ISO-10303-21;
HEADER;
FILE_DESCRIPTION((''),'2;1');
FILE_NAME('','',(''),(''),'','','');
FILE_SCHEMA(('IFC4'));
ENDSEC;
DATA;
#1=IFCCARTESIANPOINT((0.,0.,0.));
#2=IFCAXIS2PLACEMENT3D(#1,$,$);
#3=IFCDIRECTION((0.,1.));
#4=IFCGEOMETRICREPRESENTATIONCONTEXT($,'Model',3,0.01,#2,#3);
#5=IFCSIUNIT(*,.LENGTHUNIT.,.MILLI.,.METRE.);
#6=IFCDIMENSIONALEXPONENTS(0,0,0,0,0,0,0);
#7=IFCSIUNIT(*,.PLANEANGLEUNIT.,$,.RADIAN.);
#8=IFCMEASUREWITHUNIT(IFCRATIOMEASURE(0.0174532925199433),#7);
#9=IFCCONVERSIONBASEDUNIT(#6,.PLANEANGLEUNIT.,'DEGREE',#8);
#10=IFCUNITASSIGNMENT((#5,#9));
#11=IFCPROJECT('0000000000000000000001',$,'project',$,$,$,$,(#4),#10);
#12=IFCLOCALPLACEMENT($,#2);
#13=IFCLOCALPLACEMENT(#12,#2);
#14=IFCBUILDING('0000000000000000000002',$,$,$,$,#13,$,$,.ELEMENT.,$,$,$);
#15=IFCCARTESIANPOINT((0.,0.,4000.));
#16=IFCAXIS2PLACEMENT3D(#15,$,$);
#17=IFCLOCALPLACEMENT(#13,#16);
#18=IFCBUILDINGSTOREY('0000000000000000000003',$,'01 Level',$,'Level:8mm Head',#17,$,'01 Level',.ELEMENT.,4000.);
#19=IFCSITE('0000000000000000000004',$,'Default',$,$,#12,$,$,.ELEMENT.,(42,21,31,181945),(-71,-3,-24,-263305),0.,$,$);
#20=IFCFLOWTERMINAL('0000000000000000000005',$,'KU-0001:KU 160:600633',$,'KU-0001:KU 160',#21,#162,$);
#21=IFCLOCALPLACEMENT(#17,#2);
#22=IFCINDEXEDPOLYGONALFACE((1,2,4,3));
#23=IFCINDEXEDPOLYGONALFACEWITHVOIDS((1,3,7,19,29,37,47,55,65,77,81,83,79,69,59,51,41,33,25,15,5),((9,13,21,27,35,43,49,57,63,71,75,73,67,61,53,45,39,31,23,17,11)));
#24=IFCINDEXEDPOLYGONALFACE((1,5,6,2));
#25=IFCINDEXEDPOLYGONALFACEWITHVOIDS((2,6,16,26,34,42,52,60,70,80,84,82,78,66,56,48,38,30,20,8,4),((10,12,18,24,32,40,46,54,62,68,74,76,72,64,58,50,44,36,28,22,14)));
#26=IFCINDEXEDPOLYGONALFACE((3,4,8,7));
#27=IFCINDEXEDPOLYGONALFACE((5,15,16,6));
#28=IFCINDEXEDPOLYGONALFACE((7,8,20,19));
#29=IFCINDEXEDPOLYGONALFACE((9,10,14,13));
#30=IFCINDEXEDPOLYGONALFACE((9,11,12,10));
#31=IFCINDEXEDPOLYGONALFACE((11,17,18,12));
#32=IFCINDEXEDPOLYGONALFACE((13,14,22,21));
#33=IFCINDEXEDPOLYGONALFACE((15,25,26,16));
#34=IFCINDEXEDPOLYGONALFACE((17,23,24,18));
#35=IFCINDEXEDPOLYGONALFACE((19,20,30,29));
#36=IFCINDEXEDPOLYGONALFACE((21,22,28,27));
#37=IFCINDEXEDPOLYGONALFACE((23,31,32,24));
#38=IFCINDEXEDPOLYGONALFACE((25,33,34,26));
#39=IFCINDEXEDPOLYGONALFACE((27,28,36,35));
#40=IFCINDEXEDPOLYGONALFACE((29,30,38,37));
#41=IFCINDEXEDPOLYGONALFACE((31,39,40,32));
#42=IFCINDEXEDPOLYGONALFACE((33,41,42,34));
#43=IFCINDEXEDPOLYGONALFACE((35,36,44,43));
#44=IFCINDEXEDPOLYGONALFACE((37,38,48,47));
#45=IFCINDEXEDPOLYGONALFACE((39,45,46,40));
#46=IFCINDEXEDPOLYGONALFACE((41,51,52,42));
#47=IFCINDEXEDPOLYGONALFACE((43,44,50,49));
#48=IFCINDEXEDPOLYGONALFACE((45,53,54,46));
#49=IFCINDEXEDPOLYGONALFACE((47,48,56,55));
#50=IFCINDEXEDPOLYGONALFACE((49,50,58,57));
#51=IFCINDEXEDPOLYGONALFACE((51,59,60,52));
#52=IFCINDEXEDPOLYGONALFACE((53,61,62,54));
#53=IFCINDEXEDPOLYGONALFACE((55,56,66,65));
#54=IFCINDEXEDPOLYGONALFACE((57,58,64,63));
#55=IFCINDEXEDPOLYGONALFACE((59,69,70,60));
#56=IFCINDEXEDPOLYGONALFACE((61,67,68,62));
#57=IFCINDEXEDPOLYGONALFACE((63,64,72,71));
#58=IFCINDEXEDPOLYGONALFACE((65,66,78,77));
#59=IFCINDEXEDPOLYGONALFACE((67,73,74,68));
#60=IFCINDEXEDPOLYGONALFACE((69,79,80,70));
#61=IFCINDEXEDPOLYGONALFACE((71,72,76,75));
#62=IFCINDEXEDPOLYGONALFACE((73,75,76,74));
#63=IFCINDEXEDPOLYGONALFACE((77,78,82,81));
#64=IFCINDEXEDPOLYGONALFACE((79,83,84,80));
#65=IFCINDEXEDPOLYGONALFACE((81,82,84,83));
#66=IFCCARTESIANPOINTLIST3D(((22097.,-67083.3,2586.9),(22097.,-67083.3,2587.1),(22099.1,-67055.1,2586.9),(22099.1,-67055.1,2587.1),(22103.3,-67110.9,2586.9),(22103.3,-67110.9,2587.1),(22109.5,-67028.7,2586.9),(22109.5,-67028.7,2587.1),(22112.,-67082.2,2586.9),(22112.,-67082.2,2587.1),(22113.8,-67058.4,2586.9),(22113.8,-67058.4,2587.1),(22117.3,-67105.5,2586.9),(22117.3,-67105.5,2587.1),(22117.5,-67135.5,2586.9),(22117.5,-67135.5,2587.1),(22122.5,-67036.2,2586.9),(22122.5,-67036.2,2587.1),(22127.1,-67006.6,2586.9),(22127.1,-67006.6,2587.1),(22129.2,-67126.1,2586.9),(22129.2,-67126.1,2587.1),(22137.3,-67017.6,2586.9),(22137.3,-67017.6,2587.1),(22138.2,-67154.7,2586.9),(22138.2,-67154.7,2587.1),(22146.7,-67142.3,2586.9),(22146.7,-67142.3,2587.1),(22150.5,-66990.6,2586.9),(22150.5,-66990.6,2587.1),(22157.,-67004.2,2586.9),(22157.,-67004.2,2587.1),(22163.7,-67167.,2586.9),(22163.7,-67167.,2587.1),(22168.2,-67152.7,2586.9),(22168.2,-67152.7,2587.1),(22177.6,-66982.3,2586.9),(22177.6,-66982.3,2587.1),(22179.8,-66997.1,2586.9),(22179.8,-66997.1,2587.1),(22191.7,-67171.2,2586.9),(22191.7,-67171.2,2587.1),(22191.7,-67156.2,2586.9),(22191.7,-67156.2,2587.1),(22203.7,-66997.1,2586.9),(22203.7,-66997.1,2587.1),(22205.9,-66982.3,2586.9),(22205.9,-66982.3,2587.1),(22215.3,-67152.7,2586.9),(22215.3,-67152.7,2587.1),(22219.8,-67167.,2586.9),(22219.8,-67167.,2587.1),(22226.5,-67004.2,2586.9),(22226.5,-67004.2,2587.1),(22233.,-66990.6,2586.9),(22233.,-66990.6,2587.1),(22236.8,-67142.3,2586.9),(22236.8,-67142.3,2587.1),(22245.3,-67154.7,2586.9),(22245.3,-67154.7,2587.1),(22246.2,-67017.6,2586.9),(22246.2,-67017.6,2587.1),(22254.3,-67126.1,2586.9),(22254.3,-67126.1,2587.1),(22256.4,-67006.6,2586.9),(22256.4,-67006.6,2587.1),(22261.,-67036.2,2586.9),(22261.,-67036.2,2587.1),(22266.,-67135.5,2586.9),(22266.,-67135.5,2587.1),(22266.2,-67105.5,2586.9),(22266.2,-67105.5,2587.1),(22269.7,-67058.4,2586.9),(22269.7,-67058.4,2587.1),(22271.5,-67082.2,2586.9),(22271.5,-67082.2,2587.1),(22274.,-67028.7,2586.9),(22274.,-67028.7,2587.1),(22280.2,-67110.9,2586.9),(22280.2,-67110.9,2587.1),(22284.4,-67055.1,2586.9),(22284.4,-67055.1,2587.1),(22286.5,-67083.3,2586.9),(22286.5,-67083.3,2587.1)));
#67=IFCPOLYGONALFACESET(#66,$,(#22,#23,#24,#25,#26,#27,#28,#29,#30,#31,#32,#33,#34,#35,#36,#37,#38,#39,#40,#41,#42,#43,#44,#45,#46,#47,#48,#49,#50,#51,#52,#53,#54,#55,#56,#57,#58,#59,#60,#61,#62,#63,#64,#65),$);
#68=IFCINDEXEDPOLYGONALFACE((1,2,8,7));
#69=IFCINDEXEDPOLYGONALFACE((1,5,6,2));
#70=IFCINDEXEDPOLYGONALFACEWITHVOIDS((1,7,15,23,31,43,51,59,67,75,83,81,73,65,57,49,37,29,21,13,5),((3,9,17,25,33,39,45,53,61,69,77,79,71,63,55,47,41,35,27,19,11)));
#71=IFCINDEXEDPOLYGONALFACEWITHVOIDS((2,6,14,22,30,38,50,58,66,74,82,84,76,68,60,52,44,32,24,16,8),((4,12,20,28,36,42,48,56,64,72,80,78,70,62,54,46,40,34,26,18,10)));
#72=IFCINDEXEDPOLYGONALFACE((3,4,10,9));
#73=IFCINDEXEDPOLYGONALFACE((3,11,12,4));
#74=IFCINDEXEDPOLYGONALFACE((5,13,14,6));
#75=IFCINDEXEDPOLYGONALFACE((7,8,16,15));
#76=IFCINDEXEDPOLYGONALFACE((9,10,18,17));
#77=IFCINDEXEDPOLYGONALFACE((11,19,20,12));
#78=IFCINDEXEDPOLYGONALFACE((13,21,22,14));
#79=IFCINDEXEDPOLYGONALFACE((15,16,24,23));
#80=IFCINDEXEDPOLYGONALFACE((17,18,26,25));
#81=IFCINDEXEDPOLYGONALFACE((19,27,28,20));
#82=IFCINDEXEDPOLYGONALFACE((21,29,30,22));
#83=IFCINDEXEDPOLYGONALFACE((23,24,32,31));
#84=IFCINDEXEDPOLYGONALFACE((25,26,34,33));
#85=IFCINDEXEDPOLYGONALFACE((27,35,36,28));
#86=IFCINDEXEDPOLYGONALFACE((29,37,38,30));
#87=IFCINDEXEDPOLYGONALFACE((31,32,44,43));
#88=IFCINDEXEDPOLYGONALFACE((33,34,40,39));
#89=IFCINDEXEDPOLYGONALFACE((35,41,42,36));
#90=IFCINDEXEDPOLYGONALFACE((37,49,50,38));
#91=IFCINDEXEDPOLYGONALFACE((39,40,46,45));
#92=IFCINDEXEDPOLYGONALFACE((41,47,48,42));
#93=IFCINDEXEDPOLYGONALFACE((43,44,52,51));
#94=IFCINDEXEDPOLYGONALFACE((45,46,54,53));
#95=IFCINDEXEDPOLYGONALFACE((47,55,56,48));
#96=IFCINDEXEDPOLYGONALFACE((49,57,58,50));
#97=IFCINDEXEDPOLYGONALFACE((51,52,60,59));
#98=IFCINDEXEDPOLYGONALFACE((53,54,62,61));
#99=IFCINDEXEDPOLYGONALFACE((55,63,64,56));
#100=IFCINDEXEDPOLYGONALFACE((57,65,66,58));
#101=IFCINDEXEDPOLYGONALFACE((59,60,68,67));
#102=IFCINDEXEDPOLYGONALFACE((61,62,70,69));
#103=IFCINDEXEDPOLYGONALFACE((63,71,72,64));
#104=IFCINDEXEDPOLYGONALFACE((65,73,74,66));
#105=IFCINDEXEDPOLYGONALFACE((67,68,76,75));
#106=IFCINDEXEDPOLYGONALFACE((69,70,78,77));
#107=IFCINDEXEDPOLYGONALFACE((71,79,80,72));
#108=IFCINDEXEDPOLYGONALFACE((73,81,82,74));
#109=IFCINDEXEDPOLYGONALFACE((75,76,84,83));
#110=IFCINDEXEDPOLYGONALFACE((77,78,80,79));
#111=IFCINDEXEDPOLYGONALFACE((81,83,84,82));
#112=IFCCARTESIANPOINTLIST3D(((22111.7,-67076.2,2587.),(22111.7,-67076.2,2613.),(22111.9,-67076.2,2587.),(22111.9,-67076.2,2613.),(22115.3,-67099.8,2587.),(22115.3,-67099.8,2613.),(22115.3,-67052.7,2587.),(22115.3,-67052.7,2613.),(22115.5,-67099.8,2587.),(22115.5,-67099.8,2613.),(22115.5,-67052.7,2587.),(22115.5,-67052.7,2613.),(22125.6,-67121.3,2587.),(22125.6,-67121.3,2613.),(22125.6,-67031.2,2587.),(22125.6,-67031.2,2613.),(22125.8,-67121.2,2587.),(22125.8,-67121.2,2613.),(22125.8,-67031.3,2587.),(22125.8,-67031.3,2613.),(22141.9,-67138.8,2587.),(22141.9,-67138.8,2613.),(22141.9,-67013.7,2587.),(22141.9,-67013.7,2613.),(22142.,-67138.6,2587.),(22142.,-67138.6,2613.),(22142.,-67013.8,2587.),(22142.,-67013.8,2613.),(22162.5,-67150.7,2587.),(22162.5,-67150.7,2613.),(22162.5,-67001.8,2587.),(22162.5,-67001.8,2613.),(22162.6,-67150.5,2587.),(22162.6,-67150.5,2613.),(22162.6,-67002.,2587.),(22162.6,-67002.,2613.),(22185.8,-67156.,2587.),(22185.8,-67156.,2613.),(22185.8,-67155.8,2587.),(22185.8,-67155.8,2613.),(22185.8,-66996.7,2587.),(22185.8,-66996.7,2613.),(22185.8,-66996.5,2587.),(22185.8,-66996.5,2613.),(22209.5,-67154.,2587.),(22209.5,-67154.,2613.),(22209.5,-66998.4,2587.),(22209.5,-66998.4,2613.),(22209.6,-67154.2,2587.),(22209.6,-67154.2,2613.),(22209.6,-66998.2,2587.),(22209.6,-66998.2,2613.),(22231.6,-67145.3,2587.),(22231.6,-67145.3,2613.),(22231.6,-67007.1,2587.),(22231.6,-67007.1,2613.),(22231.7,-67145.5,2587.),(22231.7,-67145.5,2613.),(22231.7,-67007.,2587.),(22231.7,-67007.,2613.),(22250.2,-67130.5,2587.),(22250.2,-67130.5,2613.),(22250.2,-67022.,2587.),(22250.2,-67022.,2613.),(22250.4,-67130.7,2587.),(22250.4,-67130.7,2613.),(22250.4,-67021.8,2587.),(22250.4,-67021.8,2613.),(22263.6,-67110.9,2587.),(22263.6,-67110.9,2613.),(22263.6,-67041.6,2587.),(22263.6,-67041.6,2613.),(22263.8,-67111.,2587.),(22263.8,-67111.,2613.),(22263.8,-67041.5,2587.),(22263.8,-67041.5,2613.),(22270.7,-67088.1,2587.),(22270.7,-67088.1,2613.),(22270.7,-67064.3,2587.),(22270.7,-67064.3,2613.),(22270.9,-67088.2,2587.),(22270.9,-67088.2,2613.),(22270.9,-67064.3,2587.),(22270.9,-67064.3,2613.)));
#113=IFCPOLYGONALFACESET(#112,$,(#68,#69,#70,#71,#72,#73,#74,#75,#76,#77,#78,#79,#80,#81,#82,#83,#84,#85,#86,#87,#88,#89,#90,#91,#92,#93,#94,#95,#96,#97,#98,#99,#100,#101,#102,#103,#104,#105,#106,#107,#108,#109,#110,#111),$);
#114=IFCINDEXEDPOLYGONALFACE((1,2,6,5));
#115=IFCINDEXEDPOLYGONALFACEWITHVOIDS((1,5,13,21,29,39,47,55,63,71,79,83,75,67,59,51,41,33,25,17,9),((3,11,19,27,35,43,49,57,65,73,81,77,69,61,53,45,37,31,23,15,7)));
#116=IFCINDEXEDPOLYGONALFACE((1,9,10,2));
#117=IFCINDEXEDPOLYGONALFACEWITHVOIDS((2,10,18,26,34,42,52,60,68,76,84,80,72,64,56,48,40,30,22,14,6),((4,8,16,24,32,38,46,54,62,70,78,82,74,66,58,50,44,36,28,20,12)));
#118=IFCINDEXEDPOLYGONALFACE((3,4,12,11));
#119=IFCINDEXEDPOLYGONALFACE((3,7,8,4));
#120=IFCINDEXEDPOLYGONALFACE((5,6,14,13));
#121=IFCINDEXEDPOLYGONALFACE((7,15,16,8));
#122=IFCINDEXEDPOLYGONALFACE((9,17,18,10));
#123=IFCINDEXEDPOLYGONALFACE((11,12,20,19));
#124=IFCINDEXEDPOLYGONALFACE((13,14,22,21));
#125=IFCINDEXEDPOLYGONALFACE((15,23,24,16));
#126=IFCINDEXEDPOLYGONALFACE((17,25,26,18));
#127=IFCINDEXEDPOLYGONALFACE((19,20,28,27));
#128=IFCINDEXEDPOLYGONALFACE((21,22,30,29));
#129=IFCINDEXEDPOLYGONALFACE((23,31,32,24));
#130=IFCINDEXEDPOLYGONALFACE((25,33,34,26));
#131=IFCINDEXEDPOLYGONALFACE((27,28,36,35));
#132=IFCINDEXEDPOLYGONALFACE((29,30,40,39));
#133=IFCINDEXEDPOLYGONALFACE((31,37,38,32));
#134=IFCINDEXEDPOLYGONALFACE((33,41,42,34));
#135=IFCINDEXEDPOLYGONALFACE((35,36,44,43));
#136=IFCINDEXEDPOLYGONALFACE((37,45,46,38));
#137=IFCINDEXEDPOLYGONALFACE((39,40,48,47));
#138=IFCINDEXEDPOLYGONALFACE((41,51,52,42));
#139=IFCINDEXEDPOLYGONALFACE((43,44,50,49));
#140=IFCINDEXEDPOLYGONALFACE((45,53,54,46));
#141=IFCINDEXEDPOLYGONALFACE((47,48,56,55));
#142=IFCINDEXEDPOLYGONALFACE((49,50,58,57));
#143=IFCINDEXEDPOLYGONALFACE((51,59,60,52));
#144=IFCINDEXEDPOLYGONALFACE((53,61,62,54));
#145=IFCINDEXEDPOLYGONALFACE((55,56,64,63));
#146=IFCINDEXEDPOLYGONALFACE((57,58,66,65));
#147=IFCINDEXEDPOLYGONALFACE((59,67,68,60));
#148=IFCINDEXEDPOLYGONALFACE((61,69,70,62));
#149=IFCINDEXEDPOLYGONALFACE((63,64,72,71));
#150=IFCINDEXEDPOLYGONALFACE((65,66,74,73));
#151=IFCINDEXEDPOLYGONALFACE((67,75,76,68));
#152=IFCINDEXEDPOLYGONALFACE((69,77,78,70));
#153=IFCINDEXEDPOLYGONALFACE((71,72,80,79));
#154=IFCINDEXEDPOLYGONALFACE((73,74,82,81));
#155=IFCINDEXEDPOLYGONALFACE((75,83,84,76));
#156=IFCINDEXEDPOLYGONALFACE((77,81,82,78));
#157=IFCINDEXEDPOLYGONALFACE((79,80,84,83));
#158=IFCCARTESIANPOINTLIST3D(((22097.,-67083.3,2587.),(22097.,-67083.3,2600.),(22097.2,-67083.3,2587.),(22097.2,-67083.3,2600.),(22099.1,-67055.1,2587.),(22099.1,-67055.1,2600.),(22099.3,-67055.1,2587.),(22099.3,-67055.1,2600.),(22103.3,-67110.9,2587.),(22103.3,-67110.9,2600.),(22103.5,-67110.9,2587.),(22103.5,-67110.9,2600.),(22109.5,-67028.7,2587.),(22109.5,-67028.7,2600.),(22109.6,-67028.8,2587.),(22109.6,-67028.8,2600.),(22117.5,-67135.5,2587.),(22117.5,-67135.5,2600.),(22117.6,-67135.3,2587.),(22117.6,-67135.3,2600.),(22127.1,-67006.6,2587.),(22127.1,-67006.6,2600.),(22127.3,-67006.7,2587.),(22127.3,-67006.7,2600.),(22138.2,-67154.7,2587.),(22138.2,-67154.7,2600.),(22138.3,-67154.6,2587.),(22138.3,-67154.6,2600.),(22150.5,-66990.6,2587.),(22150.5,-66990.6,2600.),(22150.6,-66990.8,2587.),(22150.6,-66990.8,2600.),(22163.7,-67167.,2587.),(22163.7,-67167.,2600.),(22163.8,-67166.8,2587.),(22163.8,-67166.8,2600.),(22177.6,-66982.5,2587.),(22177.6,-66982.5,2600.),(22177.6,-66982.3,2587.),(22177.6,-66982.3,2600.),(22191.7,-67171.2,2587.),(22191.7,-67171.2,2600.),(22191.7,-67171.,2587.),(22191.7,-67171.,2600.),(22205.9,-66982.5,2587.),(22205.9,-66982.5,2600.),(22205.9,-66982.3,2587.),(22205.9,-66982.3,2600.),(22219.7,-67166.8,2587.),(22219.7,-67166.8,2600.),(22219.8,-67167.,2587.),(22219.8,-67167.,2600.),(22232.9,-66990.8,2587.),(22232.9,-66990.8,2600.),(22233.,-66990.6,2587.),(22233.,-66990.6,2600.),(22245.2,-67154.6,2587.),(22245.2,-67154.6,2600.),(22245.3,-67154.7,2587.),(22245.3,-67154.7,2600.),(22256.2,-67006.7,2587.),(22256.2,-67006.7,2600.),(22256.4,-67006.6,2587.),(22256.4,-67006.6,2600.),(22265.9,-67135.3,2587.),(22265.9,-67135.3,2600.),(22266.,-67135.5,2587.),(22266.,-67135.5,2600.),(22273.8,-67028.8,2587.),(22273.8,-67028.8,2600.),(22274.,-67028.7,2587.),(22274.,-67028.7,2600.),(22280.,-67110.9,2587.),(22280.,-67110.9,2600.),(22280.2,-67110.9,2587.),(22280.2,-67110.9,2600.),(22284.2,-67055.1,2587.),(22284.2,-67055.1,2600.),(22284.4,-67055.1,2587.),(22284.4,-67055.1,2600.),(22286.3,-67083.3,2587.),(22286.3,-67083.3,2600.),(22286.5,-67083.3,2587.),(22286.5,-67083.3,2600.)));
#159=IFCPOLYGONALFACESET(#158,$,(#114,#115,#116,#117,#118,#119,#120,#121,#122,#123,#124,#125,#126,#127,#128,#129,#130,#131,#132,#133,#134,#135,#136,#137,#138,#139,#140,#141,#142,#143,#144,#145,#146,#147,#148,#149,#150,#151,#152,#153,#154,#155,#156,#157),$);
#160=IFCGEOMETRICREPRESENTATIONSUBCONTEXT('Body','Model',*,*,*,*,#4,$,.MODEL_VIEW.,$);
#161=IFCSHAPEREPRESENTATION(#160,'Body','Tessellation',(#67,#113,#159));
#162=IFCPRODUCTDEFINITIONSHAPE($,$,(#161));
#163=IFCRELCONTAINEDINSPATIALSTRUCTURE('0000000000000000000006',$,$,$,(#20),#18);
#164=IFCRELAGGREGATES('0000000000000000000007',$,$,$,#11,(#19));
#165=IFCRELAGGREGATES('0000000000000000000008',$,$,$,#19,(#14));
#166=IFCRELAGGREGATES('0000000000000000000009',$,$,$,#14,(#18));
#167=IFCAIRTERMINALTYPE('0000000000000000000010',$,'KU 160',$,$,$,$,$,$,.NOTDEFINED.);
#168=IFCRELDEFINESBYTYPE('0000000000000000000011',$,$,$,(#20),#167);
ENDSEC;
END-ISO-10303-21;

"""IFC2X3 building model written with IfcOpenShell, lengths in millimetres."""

from ifc_helpers import new_model, entity, si_unit, converted_unit, direction, frame, frame_2d, origin, place, context, subcontext, project, spatial, hollow_circle, extrude, source, transform, mapped, type_object, type_shapes, element, save


model = new_model("IFC2X3")

# Units and contexts
model_context = context("Model", 3, precision=0.01, world=origin(), true_north=direction((0.0, 1.0)))
body_context = subcontext(model_context, "Body", "Model", "MODEL_VIEW")
ifc_project = project(units=[si_unit("LENGTHUNIT", "METRE", prefix="MILLI"), converted_unit("PLANEANGLEUNIT", "DEGREE", entity("IfcRatioMeasure", 0.0174532925199433), si_unit("PLANEANGLEUNIT", "RADIAN"), dimensions=[0, 0, 0, 0, 0, 0, 0])], contexts=[model_context])

# Site, building, storey
site_placement = place(None, origin())
site = spatial("IfcSite", under=ifc_project, at=site_placement, Name="Default", CompositionType="ELEMENT", RefLatitude=(42, 21, 31, 181945), RefLongitude=(-71, -3, -24, -263305), RefElevation=0.0)
building_placement = place(site_placement, origin())
building = spatial("IfcBuilding", under=site, at=building_placement, CompositionType="ELEMENT")
storey_placement = place(building_placement, frame((0.0, 0.0, 4000.0)))
storey = spatial("IfcBuildingStorey", under=building, at=storey_placement, Name="01 Level", ObjectType="Level:8mm Head", LongName="01 Level", CompositionType="ELEMENT", Elevation=4000.0)

# Flow terminal
air_terminal_type_1 = type_object("IfcAirTerminalType", Name="KU 160", PredefinedType="NOTDEFINED")
shared_shape_1 = source(origin(), body_context, "Body", "SweptSolid", [
    extrude(hollow_circle(Radius=95.0, WallThickness=15.0, at=frame_2d((0.0, 0.0), x_axis=(1.0, 0.0))), frame((12.9, 0.0, 0.0), z_axis=(1.0, 0.0, 0.0), x_axis=(0.0, -1.0, 0.0)), (0.0, 0.0, 1.0), 0.2),
    extrude(hollow_circle(Radius=80.0, WallThickness=0.2, at=frame_2d((0.0, 0.0), x_axis=(1.0, 0.0))), frame((-13.0, 0.0, 0.0), z_axis=(1.0, 0.0, 0.0), x_axis=(0.0, 0.0, -1.0)), (0.0, 0.0, 1.0), 26.0),
    extrude(hollow_circle(Radius=95.0, WallThickness=0.2, at=frame_2d((0.0, 0.0), x_axis=(1.0, 0.0))), frame((0.0, 0.0, 0.0), z_axis=(1.0, 0.0, 0.0), x_axis=(0.0, -1.0, 0.0)), (0.0, 0.0, 1.0), 13.0),
])
type_shapes(air_terminal_type_1, [shared_shape_1])
for number, where, z_axis, x_axis, name in (
    (1, (22191.7, -67076.2, 2600.0), (1.0, 0.0, 0.0), (0.0, 0.0, -1.0), "KU-0001:KU 160:600633"),
):
    element("IfcFlowTerminal", number, at=place(storey_placement, frame(where, z_axis=z_axis, x_axis=x_axis)), inside=storey, type_object=air_terminal_type_1, Name=name, ObjectType="KU-0001:KU 160", context=body_context, shape_type="MappedRepresentation", body=[
        mapped(shared_shape_1, transform((0.0, 0.0, 0.0), scale=1.0)),
    ])

save(model, "model.ifc")
